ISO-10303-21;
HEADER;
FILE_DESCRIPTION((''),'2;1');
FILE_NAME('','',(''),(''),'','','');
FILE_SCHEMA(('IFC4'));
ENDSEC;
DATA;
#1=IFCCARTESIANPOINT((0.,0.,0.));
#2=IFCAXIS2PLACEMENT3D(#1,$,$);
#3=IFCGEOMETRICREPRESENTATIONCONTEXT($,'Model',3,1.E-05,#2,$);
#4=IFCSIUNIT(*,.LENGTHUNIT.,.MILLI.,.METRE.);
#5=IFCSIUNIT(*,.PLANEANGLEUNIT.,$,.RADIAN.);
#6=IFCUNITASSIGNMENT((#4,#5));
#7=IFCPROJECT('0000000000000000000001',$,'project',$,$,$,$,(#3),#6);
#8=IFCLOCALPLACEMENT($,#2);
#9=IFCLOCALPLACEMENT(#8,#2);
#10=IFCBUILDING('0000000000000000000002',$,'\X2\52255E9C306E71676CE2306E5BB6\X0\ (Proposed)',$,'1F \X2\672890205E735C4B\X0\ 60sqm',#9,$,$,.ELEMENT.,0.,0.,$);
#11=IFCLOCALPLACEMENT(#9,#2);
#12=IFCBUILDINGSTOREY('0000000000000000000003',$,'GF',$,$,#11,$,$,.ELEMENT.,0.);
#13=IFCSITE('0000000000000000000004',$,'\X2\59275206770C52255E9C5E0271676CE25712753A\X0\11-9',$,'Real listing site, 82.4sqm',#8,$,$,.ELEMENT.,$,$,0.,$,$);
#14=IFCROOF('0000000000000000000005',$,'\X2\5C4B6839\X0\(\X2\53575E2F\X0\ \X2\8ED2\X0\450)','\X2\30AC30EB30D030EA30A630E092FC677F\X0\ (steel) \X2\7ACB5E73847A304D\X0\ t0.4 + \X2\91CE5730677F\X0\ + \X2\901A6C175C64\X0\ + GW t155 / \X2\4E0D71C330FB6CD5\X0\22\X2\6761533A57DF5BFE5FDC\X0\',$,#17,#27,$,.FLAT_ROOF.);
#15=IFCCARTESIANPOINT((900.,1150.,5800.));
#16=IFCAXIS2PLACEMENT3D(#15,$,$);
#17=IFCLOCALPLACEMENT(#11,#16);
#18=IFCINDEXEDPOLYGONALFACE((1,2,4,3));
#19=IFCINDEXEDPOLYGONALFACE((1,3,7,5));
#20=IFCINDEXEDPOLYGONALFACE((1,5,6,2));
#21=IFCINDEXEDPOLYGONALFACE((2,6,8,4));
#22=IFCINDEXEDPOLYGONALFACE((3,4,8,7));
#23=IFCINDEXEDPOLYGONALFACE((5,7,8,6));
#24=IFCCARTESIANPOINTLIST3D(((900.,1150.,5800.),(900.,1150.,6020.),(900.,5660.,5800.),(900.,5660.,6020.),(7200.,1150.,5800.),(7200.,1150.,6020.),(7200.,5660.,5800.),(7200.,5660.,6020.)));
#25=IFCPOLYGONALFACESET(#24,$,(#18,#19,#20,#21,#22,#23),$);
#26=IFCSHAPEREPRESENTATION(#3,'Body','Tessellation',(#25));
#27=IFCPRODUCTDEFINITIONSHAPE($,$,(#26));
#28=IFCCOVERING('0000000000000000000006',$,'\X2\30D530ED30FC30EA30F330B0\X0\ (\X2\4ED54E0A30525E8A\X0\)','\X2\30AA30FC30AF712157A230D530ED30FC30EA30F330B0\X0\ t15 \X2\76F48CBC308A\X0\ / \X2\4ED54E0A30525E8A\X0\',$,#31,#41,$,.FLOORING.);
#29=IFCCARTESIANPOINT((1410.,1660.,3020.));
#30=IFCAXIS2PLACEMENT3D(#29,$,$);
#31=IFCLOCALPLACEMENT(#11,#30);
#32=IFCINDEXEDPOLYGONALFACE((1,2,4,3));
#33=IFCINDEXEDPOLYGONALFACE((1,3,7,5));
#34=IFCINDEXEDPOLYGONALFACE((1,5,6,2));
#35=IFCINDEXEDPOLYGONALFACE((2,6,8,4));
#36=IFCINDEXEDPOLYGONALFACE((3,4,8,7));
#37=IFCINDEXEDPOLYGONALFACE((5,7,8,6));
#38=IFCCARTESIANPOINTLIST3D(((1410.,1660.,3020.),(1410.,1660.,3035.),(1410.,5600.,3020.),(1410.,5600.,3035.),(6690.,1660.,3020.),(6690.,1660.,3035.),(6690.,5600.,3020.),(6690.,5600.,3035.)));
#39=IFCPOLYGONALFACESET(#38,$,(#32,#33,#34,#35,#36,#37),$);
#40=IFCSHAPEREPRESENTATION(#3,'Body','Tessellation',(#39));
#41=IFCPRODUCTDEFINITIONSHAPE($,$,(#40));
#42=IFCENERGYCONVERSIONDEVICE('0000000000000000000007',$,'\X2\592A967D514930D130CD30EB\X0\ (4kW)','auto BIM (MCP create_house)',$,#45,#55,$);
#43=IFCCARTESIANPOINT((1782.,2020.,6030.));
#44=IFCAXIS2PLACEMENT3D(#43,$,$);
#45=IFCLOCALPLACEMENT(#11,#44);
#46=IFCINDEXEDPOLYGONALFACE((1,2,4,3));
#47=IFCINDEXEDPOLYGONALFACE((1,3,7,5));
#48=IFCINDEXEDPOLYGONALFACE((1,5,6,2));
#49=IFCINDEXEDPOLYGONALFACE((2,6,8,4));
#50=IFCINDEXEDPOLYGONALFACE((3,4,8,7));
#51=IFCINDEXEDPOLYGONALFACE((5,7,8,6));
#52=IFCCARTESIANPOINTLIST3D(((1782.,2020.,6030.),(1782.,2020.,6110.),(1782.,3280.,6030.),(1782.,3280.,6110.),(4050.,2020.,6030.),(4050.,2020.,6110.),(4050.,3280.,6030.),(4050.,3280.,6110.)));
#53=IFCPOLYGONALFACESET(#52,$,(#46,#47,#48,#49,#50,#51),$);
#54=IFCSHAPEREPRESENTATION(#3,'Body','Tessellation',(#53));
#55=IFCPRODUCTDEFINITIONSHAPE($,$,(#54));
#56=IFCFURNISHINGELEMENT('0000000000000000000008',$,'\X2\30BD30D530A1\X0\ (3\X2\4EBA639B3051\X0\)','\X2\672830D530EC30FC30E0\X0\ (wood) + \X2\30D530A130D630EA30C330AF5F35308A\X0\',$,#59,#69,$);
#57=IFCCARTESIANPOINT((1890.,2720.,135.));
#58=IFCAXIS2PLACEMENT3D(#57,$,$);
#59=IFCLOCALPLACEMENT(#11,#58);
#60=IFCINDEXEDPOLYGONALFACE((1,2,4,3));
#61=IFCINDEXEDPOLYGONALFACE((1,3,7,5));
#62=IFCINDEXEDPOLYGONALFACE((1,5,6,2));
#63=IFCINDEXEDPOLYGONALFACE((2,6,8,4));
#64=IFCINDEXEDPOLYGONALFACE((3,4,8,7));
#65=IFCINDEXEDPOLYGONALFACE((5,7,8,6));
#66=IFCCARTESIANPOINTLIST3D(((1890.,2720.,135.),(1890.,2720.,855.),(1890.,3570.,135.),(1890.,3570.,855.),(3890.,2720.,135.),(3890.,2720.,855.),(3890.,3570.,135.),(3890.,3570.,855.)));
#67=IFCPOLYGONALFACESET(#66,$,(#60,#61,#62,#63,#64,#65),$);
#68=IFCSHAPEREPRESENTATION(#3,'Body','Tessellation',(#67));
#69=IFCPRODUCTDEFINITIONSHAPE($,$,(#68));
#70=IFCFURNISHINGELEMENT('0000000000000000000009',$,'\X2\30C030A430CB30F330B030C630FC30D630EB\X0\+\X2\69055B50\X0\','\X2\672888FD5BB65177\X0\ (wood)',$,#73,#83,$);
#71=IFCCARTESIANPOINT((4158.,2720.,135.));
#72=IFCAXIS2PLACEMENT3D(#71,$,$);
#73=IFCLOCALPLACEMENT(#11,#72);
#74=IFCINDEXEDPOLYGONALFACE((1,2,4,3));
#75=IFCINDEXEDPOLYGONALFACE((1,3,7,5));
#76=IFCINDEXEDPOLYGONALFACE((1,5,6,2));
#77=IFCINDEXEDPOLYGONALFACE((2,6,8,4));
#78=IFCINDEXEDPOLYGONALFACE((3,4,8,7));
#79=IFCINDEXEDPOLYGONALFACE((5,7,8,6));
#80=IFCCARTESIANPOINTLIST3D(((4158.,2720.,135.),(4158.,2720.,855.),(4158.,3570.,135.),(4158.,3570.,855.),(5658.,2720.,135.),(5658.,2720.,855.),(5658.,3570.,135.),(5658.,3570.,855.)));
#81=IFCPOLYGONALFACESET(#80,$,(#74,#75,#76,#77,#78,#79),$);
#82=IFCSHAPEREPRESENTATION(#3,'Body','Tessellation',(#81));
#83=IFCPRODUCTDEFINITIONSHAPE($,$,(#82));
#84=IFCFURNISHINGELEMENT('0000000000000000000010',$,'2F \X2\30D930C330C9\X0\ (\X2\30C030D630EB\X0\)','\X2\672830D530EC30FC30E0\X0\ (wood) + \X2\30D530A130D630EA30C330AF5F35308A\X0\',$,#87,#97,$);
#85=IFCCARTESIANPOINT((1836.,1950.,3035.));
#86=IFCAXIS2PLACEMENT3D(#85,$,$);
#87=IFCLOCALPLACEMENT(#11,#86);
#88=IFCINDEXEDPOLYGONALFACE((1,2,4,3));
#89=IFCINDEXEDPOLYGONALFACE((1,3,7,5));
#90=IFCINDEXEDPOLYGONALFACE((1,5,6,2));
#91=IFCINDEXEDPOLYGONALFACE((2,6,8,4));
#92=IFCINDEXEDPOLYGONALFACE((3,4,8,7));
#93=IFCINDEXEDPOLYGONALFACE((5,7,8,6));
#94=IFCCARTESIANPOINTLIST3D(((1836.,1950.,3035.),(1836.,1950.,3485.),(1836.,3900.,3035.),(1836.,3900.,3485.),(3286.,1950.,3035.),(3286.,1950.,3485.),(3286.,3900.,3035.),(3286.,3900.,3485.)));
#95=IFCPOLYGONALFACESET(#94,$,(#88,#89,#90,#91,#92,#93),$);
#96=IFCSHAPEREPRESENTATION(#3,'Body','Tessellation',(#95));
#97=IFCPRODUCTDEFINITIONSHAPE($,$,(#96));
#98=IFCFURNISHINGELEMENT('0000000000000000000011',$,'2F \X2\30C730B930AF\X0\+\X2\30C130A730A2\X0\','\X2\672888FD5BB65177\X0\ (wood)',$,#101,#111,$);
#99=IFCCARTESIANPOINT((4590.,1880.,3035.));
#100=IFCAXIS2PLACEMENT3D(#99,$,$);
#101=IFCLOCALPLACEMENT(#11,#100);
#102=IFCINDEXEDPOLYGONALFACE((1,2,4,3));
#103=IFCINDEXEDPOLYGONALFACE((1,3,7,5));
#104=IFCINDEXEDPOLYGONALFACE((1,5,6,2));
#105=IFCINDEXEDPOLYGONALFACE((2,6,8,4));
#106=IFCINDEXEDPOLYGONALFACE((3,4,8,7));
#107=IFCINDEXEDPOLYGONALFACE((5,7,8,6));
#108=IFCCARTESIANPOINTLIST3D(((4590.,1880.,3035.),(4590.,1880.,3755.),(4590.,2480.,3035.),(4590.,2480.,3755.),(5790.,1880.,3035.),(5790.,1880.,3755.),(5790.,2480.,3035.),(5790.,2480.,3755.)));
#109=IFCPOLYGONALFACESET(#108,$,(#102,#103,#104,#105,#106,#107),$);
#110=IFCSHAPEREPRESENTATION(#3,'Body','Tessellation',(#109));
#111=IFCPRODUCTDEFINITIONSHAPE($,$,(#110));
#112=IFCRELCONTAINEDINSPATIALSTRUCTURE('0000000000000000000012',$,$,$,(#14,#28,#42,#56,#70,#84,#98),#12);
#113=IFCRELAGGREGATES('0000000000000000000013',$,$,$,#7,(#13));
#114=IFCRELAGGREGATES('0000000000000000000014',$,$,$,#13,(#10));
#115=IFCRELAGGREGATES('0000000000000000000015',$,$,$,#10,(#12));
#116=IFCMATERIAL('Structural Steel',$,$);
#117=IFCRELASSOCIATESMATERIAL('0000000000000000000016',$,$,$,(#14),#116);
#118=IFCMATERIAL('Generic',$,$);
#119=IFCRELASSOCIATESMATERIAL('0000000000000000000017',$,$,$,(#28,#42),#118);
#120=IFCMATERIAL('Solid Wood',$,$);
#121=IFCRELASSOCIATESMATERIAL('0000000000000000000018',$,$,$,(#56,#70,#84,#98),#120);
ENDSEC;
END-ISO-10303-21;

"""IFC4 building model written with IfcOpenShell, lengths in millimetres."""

from ifc_helpers import new_model, si_unit, frame, frame_2d, origin, place, context, project, spatial, rectangle, extrude, material, element, save


model = new_model("IFC4")

# Units and contexts
model_context = context("Model", 3, precision=1e-05, world=origin())
ifc_project = project(units=[si_unit("LENGTHUNIT", "METRE", prefix="MILLI"), si_unit("PLANEANGLEUNIT", "RADIAN")], contexts=[model_context])

# Site, building, storey
site_placement = place(None, origin())
site = spatial("IfcSite", under=ifc_project, at=site_placement, Name="大分県別府市照波園町11-9", ObjectType="Real listing site, 82.4sqm", CompositionType="ELEMENT", RefElevation=0.0)
building_placement = place(site_placement, origin())
building = spatial("IfcBuilding", under=site, at=building_placement, Name="別府の照波の家 (Proposed)", ObjectType="1F 木造平屋 60sqm", CompositionType="ELEMENT", ElevationOfRefHeight=0.0, ElevationOfTerrain=0.0)
storey_placement = place(building_placement, origin())
storey = spatial("IfcBuildingStorey", under=building, at=storey_placement, Name="GF", CompositionType="ELEMENT", Elevation=0.0)

# Shared definitions
ifc_material_1 = material(Name="Solid Wood")

# Shared definitions
ifc_material_2 = material(Name="Generic")

# Roof
ifc_material_3 = material(Name="Structural Steel")
for number, where, name in (
    (1, (900.0, 1150.0, 5800.0), "屋根(南帯 軒450)"),
):
    element("IfcRoof", number, at=place(storey_placement, frame(where)), inside=storey, material=ifc_material_3, Name=name, Description="ガルバリウム鋼板 (steel) 立平葺き t0.4 + 野地板 + 通気層 + GW t155 / 不燃・法22条区域対応", PredefinedType="FLAT_ROOF", context=model_context, shape_type="SweptSolid", body=[
        extrude(rectangle(XDim=6300.0, YDim=4510.0, at=frame_2d((3150.0, 2255.0))), frame((900.0, 1150.0, 5800.0)), (0.0, 0.0, 1.0), 220.0),
    ])

# Covering
covering_placement = place(storey_placement, frame((1410.0, 1660.0, 3020.0)))
element("IfcCovering", 2, at=covering_placement, inside=storey, material=ifc_material_2, Name="フローリング (仕上げ床)", Description="オーク無垢フローリング t15 直貼り / 仕上げ床", PredefinedType="FLOORING", context=model_context, shape_type="SweptSolid", body=[
    extrude(rectangle(XDim=5280.0, YDim=3940.0, at=frame_2d((2640.0, 1970.0))), frame((1410.0, 1660.0, 3020.0)), (0.0, 0.0, 1.0), 15.0),
])

# Energy conversion device
energy_conversion_device_placement = place(storey_placement, frame((1782.0, 2020.0, 6030.0)))
element("IfcEnergyConversionDevice", 3, at=energy_conversion_device_placement, inside=storey, material=ifc_material_2, Name="太陽光パネル (4kW)", Description="auto BIM (MCP create_house)", context=model_context, shape_type="SweptSolid", body=[
    extrude(rectangle(XDim=2268.0, YDim=1260.0, at=frame_2d((1134.0, 630.0))), frame((1782.0, 2020.0, 6030.0)), (0.0, 0.0, 1.0), 80.0),
])

# Furnishing elements
furnishing_1_placement = place(storey_placement, frame((1890.0, 2720.0, 135.0)))
element("IfcFurnishingElement", 4, at=furnishing_1_placement, inside=storey, material=ifc_material_1, Name="ソファ (3人掛け)", Description="木フレーム (wood) + ファブリック張り", context=model_context, shape_type="SweptSolid", body=[
    extrude(rectangle(XDim=2000.0, YDim=850.0, at=frame_2d((1000.0, 425.0))), frame((1890.0, 2720.0, 135.0)), (0.0, 0.0, 1.0), 720.0),
])
furnishing_2_placement = place(storey_placement, frame((4158.0, 2720.0, 135.0)))
element("IfcFurnishingElement", 5, at=furnishing_2_placement, inside=storey, material=ifc_material_1, Name="ダイニングテーブル+椅子", Description="木製家具 (wood)", context=model_context, shape_type="SweptSolid", body=[
    extrude(rectangle(XDim=1500.0, YDim=850.0, at=frame_2d((750.0, 425.0))), frame((4158.0, 2720.0, 135.0)), (0.0, 0.0, 1.0), 720.0),
])
furnishing_3_placement = place(storey_placement, frame((1836.0, 1950.0, 3035.0)))
element("IfcFurnishingElement", 6, at=furnishing_3_placement, inside=storey, material=ifc_material_1, Name="2F ベッド (ダブル)", Description="木フレーム (wood) + ファブリック張り", context=model_context, shape_type="SweptSolid", body=[
    extrude(rectangle(XDim=1450.0, YDim=1950.0, at=frame_2d((725.0, 975.0))), frame((1836.0, 1950.0, 3035.0)), (0.0, 0.0, 1.0), 450.0),
])
furnishing_4_placement = place(storey_placement, frame((4590.0, 1880.0, 3035.0)))
element("IfcFurnishingElement", 7, at=furnishing_4_placement, inside=storey, material=ifc_material_1, Name="2F デスク+チェア", Description="木製家具 (wood)", context=model_context, shape_type="SweptSolid", body=[
    extrude(rectangle(XDim=1200.0, YDim=600.0, at=frame_2d((600.0, 300.0))), frame((4590.0, 1880.0, 3035.0)), (0.0, 0.0, 1.0), 720.0),
])

save(model, "model.ifc")
